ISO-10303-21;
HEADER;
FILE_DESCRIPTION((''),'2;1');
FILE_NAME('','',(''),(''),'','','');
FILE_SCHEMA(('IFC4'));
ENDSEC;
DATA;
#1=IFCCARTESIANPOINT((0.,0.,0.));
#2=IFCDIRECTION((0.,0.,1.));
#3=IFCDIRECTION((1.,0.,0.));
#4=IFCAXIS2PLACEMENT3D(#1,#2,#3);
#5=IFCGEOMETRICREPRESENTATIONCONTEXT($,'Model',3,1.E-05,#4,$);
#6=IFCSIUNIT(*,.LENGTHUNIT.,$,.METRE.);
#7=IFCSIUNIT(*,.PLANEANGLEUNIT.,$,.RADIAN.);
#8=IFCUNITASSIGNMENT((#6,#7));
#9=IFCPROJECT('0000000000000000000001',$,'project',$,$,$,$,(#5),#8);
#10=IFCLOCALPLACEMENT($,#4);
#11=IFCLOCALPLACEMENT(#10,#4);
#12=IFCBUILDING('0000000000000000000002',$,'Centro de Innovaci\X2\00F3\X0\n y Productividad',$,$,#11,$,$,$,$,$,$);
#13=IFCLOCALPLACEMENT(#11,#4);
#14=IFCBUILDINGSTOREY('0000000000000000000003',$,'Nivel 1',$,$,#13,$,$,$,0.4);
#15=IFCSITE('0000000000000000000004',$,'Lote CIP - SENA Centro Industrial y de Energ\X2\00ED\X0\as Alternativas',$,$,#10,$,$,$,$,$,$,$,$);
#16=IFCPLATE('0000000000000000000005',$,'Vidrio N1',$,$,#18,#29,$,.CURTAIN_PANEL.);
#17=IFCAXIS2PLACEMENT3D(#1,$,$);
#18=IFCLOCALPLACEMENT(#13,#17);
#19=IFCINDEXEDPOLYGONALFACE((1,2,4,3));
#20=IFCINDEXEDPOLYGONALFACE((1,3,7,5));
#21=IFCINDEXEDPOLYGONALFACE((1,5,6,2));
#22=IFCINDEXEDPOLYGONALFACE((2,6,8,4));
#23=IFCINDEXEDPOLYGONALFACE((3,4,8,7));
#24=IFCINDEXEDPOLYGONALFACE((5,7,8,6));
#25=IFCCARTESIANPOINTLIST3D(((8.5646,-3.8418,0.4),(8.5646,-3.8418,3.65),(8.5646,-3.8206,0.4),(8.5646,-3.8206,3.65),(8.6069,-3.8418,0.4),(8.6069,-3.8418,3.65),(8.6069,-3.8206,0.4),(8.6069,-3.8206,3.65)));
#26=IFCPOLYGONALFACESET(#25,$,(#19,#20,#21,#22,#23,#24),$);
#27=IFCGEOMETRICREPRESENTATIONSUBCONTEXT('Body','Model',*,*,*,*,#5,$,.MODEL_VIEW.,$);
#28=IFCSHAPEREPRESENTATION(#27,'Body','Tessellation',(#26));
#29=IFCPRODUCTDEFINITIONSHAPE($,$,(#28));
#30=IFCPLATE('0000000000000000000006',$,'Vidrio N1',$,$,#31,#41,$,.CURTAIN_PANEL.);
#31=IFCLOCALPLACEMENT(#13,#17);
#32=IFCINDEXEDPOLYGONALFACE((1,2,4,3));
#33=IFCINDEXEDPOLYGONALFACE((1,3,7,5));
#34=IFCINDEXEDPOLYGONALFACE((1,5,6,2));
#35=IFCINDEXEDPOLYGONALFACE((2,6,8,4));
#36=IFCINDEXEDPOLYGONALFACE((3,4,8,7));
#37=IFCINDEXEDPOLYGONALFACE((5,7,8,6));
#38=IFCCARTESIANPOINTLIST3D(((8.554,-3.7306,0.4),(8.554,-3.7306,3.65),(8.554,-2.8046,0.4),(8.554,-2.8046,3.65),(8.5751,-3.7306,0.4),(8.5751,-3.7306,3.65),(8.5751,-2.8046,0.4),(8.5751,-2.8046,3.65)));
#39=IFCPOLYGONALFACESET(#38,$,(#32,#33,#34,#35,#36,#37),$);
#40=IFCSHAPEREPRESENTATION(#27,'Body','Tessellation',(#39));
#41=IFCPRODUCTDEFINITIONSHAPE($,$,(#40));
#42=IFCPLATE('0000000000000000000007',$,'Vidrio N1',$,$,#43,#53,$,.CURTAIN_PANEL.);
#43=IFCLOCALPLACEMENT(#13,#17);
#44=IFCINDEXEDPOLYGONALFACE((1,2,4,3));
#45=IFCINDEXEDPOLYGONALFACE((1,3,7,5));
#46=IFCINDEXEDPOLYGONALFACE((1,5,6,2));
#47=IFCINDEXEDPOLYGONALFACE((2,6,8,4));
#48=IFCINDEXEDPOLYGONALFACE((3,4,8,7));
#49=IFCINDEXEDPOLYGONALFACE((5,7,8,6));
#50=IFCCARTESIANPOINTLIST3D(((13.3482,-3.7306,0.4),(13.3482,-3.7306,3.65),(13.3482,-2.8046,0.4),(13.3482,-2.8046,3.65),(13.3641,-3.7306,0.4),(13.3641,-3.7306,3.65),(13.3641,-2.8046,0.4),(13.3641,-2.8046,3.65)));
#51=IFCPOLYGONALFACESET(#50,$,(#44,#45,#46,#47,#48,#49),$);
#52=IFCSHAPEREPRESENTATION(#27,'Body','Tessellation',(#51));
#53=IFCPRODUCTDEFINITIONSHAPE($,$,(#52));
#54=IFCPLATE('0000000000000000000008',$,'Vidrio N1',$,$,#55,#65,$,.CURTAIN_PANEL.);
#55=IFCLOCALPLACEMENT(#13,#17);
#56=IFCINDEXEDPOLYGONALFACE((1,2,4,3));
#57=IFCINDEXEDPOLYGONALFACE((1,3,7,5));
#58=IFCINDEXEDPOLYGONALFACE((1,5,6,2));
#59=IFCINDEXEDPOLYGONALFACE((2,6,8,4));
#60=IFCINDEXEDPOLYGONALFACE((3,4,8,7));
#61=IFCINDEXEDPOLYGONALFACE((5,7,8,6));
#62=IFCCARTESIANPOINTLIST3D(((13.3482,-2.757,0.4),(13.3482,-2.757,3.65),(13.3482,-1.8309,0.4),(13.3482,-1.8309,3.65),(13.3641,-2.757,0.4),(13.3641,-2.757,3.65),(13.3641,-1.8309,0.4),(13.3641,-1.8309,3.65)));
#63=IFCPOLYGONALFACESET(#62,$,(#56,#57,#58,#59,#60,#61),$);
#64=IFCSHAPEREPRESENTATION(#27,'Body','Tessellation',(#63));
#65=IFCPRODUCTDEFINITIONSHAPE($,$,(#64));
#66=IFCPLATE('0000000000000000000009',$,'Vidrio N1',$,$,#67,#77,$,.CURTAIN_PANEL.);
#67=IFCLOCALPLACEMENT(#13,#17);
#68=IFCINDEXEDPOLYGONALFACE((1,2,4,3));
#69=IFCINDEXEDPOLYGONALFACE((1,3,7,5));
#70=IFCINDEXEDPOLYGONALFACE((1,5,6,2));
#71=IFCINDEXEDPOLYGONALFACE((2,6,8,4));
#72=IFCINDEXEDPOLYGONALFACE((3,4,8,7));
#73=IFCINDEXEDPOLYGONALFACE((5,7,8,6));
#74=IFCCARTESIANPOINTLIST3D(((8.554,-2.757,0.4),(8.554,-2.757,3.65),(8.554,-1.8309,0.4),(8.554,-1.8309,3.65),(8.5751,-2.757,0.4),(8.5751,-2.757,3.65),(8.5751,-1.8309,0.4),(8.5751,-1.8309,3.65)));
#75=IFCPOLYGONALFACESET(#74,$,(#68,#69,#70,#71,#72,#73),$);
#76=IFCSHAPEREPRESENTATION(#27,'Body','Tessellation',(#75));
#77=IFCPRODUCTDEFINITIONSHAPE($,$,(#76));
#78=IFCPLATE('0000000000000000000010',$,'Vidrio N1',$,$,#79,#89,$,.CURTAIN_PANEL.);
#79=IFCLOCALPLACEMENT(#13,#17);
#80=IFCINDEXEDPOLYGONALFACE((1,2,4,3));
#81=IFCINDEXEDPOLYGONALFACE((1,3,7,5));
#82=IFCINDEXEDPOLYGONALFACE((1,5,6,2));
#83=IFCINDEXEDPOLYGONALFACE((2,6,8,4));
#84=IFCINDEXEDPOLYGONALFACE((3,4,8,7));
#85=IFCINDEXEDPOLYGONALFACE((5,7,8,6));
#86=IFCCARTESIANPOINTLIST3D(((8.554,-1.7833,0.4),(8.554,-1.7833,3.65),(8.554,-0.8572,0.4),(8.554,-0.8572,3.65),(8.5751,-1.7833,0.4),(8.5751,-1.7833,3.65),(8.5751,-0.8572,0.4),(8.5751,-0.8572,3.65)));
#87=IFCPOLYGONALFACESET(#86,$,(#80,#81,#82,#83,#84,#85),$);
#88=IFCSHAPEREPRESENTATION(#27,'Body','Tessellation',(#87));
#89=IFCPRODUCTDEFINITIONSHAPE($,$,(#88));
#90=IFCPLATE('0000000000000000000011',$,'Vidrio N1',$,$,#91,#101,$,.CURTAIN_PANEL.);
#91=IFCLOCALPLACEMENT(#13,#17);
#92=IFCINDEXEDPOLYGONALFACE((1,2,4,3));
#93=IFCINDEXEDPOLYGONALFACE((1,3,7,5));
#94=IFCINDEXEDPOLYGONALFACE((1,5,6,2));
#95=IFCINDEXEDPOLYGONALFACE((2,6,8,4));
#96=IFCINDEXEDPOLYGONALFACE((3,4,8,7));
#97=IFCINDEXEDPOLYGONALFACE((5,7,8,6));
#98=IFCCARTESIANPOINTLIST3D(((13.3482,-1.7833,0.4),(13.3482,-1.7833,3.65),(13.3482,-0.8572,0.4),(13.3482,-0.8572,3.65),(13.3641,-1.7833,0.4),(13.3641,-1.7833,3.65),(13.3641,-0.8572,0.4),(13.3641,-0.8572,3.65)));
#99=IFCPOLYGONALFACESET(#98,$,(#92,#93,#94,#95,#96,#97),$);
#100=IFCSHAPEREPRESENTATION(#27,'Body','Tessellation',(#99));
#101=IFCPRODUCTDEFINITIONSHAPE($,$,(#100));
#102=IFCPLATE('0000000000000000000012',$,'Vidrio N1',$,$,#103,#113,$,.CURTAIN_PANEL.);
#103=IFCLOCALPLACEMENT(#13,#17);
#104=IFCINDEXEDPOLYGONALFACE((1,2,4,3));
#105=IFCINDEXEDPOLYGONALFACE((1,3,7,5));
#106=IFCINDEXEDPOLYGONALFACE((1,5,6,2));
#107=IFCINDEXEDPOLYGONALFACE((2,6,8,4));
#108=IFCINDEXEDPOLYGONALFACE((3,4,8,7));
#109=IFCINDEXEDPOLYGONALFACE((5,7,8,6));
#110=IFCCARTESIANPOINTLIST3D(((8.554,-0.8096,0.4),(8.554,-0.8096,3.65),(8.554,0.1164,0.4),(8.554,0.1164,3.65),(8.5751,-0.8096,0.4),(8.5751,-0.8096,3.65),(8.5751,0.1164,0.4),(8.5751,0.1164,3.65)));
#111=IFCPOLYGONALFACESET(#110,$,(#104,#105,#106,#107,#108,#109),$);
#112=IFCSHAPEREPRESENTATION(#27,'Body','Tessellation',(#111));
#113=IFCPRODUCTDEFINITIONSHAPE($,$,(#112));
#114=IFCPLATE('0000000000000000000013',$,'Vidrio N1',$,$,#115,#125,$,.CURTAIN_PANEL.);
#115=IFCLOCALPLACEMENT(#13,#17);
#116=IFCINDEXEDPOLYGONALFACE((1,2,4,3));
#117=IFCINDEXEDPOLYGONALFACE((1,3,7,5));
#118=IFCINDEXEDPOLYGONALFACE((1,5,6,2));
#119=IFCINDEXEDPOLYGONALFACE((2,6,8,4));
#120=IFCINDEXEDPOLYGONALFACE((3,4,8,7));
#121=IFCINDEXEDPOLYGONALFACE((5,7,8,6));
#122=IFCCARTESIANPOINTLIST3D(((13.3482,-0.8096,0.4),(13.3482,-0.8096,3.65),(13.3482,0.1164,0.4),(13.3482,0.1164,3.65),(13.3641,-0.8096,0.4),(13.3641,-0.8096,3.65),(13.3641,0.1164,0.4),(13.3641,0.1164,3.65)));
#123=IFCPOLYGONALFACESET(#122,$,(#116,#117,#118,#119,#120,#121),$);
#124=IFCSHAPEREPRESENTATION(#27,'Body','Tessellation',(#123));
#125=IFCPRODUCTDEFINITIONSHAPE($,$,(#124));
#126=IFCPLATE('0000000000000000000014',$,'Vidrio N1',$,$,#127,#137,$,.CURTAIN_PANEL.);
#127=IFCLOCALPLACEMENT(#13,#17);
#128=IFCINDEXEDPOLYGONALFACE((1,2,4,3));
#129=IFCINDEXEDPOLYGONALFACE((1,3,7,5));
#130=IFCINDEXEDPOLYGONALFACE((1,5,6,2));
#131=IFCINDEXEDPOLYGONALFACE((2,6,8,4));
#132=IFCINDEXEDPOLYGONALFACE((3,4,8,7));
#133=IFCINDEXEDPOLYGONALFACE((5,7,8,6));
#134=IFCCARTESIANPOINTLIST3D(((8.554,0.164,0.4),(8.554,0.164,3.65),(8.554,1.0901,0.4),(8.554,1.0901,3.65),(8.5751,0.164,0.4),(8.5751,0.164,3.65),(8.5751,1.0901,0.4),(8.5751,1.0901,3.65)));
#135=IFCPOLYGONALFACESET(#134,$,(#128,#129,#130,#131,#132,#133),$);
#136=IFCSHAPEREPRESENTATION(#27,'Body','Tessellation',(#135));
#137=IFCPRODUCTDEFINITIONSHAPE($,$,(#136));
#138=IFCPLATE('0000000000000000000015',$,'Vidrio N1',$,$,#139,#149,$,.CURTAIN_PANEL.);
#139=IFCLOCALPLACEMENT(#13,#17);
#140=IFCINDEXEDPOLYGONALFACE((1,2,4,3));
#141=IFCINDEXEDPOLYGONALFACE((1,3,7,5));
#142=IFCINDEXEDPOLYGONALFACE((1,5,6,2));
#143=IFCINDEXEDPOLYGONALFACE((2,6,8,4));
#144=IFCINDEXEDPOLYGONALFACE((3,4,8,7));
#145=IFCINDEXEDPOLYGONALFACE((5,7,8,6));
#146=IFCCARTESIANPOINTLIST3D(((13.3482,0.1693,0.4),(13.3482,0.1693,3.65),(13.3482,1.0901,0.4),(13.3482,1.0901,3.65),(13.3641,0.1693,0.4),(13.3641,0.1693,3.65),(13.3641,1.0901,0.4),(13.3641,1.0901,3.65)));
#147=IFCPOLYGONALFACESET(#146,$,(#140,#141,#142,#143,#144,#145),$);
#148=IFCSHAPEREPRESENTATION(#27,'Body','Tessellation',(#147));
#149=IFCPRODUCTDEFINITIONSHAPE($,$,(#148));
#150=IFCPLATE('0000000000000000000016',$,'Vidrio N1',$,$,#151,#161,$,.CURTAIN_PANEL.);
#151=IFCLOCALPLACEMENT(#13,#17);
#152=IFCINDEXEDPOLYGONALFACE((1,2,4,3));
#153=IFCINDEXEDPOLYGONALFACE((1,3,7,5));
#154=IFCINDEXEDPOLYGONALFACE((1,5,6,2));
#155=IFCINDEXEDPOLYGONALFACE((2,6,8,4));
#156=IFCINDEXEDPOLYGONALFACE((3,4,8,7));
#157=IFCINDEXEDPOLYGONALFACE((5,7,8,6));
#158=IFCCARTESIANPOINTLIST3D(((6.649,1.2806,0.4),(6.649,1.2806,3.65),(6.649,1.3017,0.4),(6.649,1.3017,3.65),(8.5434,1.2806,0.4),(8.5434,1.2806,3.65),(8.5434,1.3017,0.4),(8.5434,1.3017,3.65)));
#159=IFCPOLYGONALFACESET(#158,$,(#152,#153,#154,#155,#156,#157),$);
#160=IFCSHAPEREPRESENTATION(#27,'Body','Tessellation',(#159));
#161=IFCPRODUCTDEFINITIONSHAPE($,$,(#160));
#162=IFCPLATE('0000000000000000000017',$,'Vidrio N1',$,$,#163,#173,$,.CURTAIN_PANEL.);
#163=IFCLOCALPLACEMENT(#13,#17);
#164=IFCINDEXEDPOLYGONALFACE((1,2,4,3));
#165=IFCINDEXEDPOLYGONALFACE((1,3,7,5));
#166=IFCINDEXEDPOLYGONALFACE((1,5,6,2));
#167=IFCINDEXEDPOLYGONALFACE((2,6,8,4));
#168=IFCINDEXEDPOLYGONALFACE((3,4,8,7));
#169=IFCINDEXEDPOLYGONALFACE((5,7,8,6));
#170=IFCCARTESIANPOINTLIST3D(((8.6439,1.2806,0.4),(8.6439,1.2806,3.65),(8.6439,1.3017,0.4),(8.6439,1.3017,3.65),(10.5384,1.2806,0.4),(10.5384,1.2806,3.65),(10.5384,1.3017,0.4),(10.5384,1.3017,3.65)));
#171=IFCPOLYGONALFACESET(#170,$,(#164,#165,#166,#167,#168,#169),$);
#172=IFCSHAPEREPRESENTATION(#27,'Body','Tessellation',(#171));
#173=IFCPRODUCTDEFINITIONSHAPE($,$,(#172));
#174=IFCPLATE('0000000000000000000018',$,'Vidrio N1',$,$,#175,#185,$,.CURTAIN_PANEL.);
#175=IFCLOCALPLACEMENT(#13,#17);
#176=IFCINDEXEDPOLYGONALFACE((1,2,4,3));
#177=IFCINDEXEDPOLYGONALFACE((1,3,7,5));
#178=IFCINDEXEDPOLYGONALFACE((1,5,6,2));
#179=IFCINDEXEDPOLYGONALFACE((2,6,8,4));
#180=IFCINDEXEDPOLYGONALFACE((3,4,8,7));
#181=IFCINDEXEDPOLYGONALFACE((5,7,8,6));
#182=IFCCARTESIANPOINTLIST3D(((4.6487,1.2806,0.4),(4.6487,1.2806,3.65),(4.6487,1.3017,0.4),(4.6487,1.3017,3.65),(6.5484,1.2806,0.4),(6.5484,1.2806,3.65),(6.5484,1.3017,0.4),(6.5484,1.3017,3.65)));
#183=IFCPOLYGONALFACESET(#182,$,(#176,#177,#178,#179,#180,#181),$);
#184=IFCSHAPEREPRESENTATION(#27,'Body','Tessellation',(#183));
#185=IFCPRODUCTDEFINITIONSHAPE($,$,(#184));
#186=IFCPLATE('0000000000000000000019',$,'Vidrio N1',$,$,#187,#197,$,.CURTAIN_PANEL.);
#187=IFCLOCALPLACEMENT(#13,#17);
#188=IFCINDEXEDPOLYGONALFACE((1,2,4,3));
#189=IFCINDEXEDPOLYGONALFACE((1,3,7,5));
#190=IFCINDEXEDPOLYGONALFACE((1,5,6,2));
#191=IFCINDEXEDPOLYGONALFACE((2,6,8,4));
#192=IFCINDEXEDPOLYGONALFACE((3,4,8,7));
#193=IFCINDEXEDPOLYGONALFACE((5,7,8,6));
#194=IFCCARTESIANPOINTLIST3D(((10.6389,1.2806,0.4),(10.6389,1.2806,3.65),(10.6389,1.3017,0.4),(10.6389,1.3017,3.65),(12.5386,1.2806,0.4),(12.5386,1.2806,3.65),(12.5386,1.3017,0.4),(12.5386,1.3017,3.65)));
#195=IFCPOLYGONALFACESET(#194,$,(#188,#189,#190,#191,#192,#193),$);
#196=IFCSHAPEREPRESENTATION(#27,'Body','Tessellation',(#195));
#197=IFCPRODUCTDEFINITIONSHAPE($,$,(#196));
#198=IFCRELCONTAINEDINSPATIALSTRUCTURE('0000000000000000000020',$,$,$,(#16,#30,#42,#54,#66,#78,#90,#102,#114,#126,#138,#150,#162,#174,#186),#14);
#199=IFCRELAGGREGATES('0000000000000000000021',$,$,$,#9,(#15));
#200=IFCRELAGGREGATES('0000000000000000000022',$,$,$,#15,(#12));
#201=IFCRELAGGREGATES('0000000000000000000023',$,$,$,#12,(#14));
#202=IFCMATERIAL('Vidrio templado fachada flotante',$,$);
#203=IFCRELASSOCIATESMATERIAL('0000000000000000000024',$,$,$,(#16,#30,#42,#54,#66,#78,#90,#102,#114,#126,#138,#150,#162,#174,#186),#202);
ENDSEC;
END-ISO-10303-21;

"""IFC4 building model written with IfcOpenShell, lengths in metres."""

from ifc_helpers import new_model, si_unit, frame, origin_with_axes, place, context, subcontext, project, spatial, polyline, outline, extrude, material, element, save


model = new_model("IFC4")

# Units and contexts
model_context = context("Model", 3, precision=1e-05, world=origin_with_axes())
body_context = subcontext(model_context, "Body", "Model", "MODEL_VIEW")
ifc_project = project(units=[si_unit("LENGTHUNIT", "METRE"), si_unit("PLANEANGLEUNIT", "RADIAN")], contexts=[model_context])

# Site, building, storey
site_placement = place(None, origin_with_axes())
site = spatial("IfcSite", under=ifc_project, at=site_placement, Name="Lote CIP - SENA Centro Industrial y de Energías Alternativas")
building_placement = place(site_placement, origin_with_axes())
building = spatial("IfcBuilding", under=site, at=building_placement, Name="Centro de Innovación y Productividad")
storey_placement = place(building_placement, origin_with_axes())
storey = spatial("IfcBuildingStorey", under=building, at=storey_placement, Name="Nivel 1", Elevation=0.4)

# Plates
ifc_material = material(Name="Vidrio templado fachada flotante")
plate_1_placement = place(storey_placement, origin_with_axes())
element("IfcPlate", 1, at=plate_1_placement, inside=storey, material=ifc_material, Name="Vidrio N1", PredefinedType="CURTAIN_PANEL", context=body_context, shape_type="SweptSolid", body=[
    extrude(outline(polyline([(8.6069, -3.8206), (8.6069, -3.8417), (8.5646, -3.8417), (8.5646, -3.8206), (8.6069, -3.8206)])), frame((0.0, 0.0, 0.4)), (0.0, 0.0, 1.0), 3.25),
])
plate_2_placement = place(storey_placement, origin_with_axes())
element("IfcPlate", 2, at=plate_2_placement, inside=storey, material=ifc_material, Name="Vidrio N1", PredefinedType="CURTAIN_PANEL", context=body_context, shape_type="SweptSolid", body=[
    extrude(outline(polyline([(8.5751, -3.7306), (8.554, -3.7306), (8.554, -2.8046), (8.5751, -2.8046), (8.5751, -3.7306)])), frame((0.0, 0.0, 0.4)), (0.0, 0.0, 1.0), 3.25),
])
plate_3_placement = place(storey_placement, origin_with_axes())
element("IfcPlate", 3, at=plate_3_placement, inside=storey, material=ifc_material, Name="Vidrio N1", PredefinedType="CURTAIN_PANEL", context=body_context, shape_type="SweptSolid", body=[
    extrude(outline(polyline([(13.3482, -2.8046), (13.3641, -2.8046), (13.3641, -3.7306), (13.3482, -3.7306), (13.3482, -2.8046)])), frame((0.0, 0.0, 0.4)), (0.0, 0.0, 1.0), 3.25),
])
plate_4_placement = place(storey_placement, origin_with_axes())
element("IfcPlate", 4, at=plate_4_placement, inside=storey, material=ifc_material, Name="Vidrio N1", PredefinedType="CURTAIN_PANEL", context=body_context, shape_type="SweptSolid", body=[
    extrude(outline(polyline([(13.3641, -2.757), (13.3482, -2.757), (13.3482, -1.8309), (13.3641, -1.8309), (13.3641, -2.757)])), frame((0.0, 0.0, 0.4)), (0.0, 0.0, 1.0), 3.25),
])
plate_5_placement = place(storey_placement, origin_with_axes())
element("IfcPlate", 5, at=plate_5_placement, inside=storey, material=ifc_material, Name="Vidrio N1", PredefinedType="CURTAIN_PANEL", context=body_context, shape_type="SweptSolid", body=[
    extrude(outline(polyline([(8.554, -1.8309), (8.5751, -1.8309), (8.5751, -2.757), (8.554, -2.757), (8.554, -1.8309)])), frame((0.0, 0.0, 0.4)), (0.0, 0.0, 1.0), 3.25),
])
plate_6_placement = place(storey_placement, origin_with_axes())
element("IfcPlate", 6, at=plate_6_placement, inside=storey, material=ifc_material, Name="Vidrio N1", PredefinedType="CURTAIN_PANEL", context=body_context, shape_type="SweptSolid", body=[
    extrude(outline(polyline([(8.5751, -1.7833), (8.554, -1.7833), (8.554, -0.8572), (8.5751, -0.8572), (8.5751, -1.7833)])), frame((0.0, 0.0, 0.4)), (0.0, 0.0, 1.0), 3.25),
])
plate_7_placement = place(storey_placement, origin_with_axes())
element("IfcPlate", 7, at=plate_7_placement, inside=storey, material=ifc_material, Name="Vidrio N1", PredefinedType="CURTAIN_PANEL", context=body_context, shape_type="SweptSolid", body=[
    extrude(outline(polyline([(13.3482, -1.7833), (13.3482, -0.8572), (13.3641, -0.8572), (13.3641, -1.7833), (13.3482, -1.7833)])), frame((0.0, 0.0, 0.4)), (0.0, 0.0, 1.0), 3.25),
])
plate_8_placement = place(storey_placement, origin_with_axes())
element("IfcPlate", 8, at=plate_8_placement, inside=storey, material=ifc_material, Name="Vidrio N1", PredefinedType="CURTAIN_PANEL", context=body_context, shape_type="SweptSolid", body=[
    extrude(outline(polyline([(8.5751, -0.8096), (8.554, -0.8096), (8.554, 0.1164), (8.5751, 0.1164), (8.5751, -0.8096)])), frame((0.0, 0.0, 0.4)), (0.0, 0.0, 1.0), 3.25),
])
plate_9_placement = place(storey_placement, origin_with_axes())
element("IfcPlate", 9, at=plate_9_placement, inside=storey, material=ifc_material, Name="Vidrio N1", PredefinedType="CURTAIN_PANEL", context=body_context, shape_type="SweptSolid", body=[
    extrude(outline(polyline([(13.3482, 0.1164), (13.3641, 0.1164), (13.3641, -0.8096), (13.3482, -0.8096), (13.3482, 0.1164)])), frame((0.0, 0.0, 0.4)), (0.0, 0.0, 1.0), 3.25),
])
plate_10_placement = place(storey_placement, origin_with_axes())
element("IfcPlate", 10, at=plate_10_placement, inside=storey, material=ifc_material, Name="Vidrio N1", PredefinedType="CURTAIN_PANEL", context=body_context, shape_type="SweptSolid", body=[
    extrude(outline(polyline([(8.5751, 0.164), (8.554, 0.164), (8.554, 1.0901), (8.5751, 1.0901), (8.5751, 0.164)])), frame((0.0, 0.0, 0.4)), (0.0, 0.0, 1.0), 3.25),
])
plate_11_placement = place(storey_placement, origin_with_axes())
element("IfcPlate", 11, at=plate_11_placement, inside=storey, material=ifc_material, Name="Vidrio N1", PredefinedType="CURTAIN_PANEL", context=body_context, shape_type="SweptSolid", body=[
    extrude(outline(polyline([(13.3482, 1.0901), (13.3641, 1.0901), (13.3641, 0.1693), (13.3482, 0.1693), (13.3482, 1.0901)])), frame((0.0, 0.0, 0.4)), (0.0, 0.0, 1.0), 3.25),
])
plate_12_placement = place(storey_placement, origin_with_axes())
element("IfcPlate", 12, at=plate_12_placement, inside=storey, material=ifc_material, Name="Vidrio N1", PredefinedType="CURTAIN_PANEL", context=body_context, shape_type="SweptSolid", body=[
    extrude(outline(polyline([(6.649, 1.2806), (6.649, 1.3017), (8.5434, 1.3017), (8.5434, 1.2806), (6.649, 1.2806)])), frame((0.0, 0.0, 0.4)), (0.0, 0.0, 1.0), 3.25),
])
plate_13_placement = place(storey_placement, origin_with_axes())
element("IfcPlate", 13, at=plate_13_placement, inside=storey, material=ifc_material, Name="Vidrio N1", PredefinedType="CURTAIN_PANEL", context=body_context, shape_type="SweptSolid", body=[
    extrude(outline(polyline([(10.5384, 1.3017), (10.5384, 1.2806), (8.6439, 1.2806), (8.6439, 1.3017), (10.5384, 1.3017)])), frame((0.0, 0.0, 0.4)), (0.0, 0.0, 1.0), 3.25),
])
plate_14_placement = place(storey_placement, origin_with_axes())
element("IfcPlate", 14, at=plate_14_placement, inside=storey, material=ifc_material, Name="Vidrio N1", PredefinedType="CURTAIN_PANEL", context=body_context, shape_type="SweptSolid", body=[
    extrude(outline(polyline([(4.6487, 1.2806), (4.6487, 1.3017), (6.5484, 1.3017), (6.5484, 1.2806), (4.6487, 1.2806)])), frame((0.0, 0.0, 0.4)), (0.0, 0.0, 1.0), 3.25),
])
plate_15_placement = place(storey_placement, origin_with_axes())
element("IfcPlate", 15, at=plate_15_placement, inside=storey, material=ifc_material, Name="Vidrio N1", PredefinedType="CURTAIN_PANEL", context=body_context, shape_type="SweptSolid", body=[
    extrude(outline(polyline([(12.5386, 1.2806), (10.6389, 1.2806), (10.6389, 1.3017), (12.5386, 1.3017), (12.5386, 1.2806)])), frame((0.0, 0.0, 0.4)), (0.0, 0.0, 1.0), 3.25),
])

save(model, "model.ifc")
